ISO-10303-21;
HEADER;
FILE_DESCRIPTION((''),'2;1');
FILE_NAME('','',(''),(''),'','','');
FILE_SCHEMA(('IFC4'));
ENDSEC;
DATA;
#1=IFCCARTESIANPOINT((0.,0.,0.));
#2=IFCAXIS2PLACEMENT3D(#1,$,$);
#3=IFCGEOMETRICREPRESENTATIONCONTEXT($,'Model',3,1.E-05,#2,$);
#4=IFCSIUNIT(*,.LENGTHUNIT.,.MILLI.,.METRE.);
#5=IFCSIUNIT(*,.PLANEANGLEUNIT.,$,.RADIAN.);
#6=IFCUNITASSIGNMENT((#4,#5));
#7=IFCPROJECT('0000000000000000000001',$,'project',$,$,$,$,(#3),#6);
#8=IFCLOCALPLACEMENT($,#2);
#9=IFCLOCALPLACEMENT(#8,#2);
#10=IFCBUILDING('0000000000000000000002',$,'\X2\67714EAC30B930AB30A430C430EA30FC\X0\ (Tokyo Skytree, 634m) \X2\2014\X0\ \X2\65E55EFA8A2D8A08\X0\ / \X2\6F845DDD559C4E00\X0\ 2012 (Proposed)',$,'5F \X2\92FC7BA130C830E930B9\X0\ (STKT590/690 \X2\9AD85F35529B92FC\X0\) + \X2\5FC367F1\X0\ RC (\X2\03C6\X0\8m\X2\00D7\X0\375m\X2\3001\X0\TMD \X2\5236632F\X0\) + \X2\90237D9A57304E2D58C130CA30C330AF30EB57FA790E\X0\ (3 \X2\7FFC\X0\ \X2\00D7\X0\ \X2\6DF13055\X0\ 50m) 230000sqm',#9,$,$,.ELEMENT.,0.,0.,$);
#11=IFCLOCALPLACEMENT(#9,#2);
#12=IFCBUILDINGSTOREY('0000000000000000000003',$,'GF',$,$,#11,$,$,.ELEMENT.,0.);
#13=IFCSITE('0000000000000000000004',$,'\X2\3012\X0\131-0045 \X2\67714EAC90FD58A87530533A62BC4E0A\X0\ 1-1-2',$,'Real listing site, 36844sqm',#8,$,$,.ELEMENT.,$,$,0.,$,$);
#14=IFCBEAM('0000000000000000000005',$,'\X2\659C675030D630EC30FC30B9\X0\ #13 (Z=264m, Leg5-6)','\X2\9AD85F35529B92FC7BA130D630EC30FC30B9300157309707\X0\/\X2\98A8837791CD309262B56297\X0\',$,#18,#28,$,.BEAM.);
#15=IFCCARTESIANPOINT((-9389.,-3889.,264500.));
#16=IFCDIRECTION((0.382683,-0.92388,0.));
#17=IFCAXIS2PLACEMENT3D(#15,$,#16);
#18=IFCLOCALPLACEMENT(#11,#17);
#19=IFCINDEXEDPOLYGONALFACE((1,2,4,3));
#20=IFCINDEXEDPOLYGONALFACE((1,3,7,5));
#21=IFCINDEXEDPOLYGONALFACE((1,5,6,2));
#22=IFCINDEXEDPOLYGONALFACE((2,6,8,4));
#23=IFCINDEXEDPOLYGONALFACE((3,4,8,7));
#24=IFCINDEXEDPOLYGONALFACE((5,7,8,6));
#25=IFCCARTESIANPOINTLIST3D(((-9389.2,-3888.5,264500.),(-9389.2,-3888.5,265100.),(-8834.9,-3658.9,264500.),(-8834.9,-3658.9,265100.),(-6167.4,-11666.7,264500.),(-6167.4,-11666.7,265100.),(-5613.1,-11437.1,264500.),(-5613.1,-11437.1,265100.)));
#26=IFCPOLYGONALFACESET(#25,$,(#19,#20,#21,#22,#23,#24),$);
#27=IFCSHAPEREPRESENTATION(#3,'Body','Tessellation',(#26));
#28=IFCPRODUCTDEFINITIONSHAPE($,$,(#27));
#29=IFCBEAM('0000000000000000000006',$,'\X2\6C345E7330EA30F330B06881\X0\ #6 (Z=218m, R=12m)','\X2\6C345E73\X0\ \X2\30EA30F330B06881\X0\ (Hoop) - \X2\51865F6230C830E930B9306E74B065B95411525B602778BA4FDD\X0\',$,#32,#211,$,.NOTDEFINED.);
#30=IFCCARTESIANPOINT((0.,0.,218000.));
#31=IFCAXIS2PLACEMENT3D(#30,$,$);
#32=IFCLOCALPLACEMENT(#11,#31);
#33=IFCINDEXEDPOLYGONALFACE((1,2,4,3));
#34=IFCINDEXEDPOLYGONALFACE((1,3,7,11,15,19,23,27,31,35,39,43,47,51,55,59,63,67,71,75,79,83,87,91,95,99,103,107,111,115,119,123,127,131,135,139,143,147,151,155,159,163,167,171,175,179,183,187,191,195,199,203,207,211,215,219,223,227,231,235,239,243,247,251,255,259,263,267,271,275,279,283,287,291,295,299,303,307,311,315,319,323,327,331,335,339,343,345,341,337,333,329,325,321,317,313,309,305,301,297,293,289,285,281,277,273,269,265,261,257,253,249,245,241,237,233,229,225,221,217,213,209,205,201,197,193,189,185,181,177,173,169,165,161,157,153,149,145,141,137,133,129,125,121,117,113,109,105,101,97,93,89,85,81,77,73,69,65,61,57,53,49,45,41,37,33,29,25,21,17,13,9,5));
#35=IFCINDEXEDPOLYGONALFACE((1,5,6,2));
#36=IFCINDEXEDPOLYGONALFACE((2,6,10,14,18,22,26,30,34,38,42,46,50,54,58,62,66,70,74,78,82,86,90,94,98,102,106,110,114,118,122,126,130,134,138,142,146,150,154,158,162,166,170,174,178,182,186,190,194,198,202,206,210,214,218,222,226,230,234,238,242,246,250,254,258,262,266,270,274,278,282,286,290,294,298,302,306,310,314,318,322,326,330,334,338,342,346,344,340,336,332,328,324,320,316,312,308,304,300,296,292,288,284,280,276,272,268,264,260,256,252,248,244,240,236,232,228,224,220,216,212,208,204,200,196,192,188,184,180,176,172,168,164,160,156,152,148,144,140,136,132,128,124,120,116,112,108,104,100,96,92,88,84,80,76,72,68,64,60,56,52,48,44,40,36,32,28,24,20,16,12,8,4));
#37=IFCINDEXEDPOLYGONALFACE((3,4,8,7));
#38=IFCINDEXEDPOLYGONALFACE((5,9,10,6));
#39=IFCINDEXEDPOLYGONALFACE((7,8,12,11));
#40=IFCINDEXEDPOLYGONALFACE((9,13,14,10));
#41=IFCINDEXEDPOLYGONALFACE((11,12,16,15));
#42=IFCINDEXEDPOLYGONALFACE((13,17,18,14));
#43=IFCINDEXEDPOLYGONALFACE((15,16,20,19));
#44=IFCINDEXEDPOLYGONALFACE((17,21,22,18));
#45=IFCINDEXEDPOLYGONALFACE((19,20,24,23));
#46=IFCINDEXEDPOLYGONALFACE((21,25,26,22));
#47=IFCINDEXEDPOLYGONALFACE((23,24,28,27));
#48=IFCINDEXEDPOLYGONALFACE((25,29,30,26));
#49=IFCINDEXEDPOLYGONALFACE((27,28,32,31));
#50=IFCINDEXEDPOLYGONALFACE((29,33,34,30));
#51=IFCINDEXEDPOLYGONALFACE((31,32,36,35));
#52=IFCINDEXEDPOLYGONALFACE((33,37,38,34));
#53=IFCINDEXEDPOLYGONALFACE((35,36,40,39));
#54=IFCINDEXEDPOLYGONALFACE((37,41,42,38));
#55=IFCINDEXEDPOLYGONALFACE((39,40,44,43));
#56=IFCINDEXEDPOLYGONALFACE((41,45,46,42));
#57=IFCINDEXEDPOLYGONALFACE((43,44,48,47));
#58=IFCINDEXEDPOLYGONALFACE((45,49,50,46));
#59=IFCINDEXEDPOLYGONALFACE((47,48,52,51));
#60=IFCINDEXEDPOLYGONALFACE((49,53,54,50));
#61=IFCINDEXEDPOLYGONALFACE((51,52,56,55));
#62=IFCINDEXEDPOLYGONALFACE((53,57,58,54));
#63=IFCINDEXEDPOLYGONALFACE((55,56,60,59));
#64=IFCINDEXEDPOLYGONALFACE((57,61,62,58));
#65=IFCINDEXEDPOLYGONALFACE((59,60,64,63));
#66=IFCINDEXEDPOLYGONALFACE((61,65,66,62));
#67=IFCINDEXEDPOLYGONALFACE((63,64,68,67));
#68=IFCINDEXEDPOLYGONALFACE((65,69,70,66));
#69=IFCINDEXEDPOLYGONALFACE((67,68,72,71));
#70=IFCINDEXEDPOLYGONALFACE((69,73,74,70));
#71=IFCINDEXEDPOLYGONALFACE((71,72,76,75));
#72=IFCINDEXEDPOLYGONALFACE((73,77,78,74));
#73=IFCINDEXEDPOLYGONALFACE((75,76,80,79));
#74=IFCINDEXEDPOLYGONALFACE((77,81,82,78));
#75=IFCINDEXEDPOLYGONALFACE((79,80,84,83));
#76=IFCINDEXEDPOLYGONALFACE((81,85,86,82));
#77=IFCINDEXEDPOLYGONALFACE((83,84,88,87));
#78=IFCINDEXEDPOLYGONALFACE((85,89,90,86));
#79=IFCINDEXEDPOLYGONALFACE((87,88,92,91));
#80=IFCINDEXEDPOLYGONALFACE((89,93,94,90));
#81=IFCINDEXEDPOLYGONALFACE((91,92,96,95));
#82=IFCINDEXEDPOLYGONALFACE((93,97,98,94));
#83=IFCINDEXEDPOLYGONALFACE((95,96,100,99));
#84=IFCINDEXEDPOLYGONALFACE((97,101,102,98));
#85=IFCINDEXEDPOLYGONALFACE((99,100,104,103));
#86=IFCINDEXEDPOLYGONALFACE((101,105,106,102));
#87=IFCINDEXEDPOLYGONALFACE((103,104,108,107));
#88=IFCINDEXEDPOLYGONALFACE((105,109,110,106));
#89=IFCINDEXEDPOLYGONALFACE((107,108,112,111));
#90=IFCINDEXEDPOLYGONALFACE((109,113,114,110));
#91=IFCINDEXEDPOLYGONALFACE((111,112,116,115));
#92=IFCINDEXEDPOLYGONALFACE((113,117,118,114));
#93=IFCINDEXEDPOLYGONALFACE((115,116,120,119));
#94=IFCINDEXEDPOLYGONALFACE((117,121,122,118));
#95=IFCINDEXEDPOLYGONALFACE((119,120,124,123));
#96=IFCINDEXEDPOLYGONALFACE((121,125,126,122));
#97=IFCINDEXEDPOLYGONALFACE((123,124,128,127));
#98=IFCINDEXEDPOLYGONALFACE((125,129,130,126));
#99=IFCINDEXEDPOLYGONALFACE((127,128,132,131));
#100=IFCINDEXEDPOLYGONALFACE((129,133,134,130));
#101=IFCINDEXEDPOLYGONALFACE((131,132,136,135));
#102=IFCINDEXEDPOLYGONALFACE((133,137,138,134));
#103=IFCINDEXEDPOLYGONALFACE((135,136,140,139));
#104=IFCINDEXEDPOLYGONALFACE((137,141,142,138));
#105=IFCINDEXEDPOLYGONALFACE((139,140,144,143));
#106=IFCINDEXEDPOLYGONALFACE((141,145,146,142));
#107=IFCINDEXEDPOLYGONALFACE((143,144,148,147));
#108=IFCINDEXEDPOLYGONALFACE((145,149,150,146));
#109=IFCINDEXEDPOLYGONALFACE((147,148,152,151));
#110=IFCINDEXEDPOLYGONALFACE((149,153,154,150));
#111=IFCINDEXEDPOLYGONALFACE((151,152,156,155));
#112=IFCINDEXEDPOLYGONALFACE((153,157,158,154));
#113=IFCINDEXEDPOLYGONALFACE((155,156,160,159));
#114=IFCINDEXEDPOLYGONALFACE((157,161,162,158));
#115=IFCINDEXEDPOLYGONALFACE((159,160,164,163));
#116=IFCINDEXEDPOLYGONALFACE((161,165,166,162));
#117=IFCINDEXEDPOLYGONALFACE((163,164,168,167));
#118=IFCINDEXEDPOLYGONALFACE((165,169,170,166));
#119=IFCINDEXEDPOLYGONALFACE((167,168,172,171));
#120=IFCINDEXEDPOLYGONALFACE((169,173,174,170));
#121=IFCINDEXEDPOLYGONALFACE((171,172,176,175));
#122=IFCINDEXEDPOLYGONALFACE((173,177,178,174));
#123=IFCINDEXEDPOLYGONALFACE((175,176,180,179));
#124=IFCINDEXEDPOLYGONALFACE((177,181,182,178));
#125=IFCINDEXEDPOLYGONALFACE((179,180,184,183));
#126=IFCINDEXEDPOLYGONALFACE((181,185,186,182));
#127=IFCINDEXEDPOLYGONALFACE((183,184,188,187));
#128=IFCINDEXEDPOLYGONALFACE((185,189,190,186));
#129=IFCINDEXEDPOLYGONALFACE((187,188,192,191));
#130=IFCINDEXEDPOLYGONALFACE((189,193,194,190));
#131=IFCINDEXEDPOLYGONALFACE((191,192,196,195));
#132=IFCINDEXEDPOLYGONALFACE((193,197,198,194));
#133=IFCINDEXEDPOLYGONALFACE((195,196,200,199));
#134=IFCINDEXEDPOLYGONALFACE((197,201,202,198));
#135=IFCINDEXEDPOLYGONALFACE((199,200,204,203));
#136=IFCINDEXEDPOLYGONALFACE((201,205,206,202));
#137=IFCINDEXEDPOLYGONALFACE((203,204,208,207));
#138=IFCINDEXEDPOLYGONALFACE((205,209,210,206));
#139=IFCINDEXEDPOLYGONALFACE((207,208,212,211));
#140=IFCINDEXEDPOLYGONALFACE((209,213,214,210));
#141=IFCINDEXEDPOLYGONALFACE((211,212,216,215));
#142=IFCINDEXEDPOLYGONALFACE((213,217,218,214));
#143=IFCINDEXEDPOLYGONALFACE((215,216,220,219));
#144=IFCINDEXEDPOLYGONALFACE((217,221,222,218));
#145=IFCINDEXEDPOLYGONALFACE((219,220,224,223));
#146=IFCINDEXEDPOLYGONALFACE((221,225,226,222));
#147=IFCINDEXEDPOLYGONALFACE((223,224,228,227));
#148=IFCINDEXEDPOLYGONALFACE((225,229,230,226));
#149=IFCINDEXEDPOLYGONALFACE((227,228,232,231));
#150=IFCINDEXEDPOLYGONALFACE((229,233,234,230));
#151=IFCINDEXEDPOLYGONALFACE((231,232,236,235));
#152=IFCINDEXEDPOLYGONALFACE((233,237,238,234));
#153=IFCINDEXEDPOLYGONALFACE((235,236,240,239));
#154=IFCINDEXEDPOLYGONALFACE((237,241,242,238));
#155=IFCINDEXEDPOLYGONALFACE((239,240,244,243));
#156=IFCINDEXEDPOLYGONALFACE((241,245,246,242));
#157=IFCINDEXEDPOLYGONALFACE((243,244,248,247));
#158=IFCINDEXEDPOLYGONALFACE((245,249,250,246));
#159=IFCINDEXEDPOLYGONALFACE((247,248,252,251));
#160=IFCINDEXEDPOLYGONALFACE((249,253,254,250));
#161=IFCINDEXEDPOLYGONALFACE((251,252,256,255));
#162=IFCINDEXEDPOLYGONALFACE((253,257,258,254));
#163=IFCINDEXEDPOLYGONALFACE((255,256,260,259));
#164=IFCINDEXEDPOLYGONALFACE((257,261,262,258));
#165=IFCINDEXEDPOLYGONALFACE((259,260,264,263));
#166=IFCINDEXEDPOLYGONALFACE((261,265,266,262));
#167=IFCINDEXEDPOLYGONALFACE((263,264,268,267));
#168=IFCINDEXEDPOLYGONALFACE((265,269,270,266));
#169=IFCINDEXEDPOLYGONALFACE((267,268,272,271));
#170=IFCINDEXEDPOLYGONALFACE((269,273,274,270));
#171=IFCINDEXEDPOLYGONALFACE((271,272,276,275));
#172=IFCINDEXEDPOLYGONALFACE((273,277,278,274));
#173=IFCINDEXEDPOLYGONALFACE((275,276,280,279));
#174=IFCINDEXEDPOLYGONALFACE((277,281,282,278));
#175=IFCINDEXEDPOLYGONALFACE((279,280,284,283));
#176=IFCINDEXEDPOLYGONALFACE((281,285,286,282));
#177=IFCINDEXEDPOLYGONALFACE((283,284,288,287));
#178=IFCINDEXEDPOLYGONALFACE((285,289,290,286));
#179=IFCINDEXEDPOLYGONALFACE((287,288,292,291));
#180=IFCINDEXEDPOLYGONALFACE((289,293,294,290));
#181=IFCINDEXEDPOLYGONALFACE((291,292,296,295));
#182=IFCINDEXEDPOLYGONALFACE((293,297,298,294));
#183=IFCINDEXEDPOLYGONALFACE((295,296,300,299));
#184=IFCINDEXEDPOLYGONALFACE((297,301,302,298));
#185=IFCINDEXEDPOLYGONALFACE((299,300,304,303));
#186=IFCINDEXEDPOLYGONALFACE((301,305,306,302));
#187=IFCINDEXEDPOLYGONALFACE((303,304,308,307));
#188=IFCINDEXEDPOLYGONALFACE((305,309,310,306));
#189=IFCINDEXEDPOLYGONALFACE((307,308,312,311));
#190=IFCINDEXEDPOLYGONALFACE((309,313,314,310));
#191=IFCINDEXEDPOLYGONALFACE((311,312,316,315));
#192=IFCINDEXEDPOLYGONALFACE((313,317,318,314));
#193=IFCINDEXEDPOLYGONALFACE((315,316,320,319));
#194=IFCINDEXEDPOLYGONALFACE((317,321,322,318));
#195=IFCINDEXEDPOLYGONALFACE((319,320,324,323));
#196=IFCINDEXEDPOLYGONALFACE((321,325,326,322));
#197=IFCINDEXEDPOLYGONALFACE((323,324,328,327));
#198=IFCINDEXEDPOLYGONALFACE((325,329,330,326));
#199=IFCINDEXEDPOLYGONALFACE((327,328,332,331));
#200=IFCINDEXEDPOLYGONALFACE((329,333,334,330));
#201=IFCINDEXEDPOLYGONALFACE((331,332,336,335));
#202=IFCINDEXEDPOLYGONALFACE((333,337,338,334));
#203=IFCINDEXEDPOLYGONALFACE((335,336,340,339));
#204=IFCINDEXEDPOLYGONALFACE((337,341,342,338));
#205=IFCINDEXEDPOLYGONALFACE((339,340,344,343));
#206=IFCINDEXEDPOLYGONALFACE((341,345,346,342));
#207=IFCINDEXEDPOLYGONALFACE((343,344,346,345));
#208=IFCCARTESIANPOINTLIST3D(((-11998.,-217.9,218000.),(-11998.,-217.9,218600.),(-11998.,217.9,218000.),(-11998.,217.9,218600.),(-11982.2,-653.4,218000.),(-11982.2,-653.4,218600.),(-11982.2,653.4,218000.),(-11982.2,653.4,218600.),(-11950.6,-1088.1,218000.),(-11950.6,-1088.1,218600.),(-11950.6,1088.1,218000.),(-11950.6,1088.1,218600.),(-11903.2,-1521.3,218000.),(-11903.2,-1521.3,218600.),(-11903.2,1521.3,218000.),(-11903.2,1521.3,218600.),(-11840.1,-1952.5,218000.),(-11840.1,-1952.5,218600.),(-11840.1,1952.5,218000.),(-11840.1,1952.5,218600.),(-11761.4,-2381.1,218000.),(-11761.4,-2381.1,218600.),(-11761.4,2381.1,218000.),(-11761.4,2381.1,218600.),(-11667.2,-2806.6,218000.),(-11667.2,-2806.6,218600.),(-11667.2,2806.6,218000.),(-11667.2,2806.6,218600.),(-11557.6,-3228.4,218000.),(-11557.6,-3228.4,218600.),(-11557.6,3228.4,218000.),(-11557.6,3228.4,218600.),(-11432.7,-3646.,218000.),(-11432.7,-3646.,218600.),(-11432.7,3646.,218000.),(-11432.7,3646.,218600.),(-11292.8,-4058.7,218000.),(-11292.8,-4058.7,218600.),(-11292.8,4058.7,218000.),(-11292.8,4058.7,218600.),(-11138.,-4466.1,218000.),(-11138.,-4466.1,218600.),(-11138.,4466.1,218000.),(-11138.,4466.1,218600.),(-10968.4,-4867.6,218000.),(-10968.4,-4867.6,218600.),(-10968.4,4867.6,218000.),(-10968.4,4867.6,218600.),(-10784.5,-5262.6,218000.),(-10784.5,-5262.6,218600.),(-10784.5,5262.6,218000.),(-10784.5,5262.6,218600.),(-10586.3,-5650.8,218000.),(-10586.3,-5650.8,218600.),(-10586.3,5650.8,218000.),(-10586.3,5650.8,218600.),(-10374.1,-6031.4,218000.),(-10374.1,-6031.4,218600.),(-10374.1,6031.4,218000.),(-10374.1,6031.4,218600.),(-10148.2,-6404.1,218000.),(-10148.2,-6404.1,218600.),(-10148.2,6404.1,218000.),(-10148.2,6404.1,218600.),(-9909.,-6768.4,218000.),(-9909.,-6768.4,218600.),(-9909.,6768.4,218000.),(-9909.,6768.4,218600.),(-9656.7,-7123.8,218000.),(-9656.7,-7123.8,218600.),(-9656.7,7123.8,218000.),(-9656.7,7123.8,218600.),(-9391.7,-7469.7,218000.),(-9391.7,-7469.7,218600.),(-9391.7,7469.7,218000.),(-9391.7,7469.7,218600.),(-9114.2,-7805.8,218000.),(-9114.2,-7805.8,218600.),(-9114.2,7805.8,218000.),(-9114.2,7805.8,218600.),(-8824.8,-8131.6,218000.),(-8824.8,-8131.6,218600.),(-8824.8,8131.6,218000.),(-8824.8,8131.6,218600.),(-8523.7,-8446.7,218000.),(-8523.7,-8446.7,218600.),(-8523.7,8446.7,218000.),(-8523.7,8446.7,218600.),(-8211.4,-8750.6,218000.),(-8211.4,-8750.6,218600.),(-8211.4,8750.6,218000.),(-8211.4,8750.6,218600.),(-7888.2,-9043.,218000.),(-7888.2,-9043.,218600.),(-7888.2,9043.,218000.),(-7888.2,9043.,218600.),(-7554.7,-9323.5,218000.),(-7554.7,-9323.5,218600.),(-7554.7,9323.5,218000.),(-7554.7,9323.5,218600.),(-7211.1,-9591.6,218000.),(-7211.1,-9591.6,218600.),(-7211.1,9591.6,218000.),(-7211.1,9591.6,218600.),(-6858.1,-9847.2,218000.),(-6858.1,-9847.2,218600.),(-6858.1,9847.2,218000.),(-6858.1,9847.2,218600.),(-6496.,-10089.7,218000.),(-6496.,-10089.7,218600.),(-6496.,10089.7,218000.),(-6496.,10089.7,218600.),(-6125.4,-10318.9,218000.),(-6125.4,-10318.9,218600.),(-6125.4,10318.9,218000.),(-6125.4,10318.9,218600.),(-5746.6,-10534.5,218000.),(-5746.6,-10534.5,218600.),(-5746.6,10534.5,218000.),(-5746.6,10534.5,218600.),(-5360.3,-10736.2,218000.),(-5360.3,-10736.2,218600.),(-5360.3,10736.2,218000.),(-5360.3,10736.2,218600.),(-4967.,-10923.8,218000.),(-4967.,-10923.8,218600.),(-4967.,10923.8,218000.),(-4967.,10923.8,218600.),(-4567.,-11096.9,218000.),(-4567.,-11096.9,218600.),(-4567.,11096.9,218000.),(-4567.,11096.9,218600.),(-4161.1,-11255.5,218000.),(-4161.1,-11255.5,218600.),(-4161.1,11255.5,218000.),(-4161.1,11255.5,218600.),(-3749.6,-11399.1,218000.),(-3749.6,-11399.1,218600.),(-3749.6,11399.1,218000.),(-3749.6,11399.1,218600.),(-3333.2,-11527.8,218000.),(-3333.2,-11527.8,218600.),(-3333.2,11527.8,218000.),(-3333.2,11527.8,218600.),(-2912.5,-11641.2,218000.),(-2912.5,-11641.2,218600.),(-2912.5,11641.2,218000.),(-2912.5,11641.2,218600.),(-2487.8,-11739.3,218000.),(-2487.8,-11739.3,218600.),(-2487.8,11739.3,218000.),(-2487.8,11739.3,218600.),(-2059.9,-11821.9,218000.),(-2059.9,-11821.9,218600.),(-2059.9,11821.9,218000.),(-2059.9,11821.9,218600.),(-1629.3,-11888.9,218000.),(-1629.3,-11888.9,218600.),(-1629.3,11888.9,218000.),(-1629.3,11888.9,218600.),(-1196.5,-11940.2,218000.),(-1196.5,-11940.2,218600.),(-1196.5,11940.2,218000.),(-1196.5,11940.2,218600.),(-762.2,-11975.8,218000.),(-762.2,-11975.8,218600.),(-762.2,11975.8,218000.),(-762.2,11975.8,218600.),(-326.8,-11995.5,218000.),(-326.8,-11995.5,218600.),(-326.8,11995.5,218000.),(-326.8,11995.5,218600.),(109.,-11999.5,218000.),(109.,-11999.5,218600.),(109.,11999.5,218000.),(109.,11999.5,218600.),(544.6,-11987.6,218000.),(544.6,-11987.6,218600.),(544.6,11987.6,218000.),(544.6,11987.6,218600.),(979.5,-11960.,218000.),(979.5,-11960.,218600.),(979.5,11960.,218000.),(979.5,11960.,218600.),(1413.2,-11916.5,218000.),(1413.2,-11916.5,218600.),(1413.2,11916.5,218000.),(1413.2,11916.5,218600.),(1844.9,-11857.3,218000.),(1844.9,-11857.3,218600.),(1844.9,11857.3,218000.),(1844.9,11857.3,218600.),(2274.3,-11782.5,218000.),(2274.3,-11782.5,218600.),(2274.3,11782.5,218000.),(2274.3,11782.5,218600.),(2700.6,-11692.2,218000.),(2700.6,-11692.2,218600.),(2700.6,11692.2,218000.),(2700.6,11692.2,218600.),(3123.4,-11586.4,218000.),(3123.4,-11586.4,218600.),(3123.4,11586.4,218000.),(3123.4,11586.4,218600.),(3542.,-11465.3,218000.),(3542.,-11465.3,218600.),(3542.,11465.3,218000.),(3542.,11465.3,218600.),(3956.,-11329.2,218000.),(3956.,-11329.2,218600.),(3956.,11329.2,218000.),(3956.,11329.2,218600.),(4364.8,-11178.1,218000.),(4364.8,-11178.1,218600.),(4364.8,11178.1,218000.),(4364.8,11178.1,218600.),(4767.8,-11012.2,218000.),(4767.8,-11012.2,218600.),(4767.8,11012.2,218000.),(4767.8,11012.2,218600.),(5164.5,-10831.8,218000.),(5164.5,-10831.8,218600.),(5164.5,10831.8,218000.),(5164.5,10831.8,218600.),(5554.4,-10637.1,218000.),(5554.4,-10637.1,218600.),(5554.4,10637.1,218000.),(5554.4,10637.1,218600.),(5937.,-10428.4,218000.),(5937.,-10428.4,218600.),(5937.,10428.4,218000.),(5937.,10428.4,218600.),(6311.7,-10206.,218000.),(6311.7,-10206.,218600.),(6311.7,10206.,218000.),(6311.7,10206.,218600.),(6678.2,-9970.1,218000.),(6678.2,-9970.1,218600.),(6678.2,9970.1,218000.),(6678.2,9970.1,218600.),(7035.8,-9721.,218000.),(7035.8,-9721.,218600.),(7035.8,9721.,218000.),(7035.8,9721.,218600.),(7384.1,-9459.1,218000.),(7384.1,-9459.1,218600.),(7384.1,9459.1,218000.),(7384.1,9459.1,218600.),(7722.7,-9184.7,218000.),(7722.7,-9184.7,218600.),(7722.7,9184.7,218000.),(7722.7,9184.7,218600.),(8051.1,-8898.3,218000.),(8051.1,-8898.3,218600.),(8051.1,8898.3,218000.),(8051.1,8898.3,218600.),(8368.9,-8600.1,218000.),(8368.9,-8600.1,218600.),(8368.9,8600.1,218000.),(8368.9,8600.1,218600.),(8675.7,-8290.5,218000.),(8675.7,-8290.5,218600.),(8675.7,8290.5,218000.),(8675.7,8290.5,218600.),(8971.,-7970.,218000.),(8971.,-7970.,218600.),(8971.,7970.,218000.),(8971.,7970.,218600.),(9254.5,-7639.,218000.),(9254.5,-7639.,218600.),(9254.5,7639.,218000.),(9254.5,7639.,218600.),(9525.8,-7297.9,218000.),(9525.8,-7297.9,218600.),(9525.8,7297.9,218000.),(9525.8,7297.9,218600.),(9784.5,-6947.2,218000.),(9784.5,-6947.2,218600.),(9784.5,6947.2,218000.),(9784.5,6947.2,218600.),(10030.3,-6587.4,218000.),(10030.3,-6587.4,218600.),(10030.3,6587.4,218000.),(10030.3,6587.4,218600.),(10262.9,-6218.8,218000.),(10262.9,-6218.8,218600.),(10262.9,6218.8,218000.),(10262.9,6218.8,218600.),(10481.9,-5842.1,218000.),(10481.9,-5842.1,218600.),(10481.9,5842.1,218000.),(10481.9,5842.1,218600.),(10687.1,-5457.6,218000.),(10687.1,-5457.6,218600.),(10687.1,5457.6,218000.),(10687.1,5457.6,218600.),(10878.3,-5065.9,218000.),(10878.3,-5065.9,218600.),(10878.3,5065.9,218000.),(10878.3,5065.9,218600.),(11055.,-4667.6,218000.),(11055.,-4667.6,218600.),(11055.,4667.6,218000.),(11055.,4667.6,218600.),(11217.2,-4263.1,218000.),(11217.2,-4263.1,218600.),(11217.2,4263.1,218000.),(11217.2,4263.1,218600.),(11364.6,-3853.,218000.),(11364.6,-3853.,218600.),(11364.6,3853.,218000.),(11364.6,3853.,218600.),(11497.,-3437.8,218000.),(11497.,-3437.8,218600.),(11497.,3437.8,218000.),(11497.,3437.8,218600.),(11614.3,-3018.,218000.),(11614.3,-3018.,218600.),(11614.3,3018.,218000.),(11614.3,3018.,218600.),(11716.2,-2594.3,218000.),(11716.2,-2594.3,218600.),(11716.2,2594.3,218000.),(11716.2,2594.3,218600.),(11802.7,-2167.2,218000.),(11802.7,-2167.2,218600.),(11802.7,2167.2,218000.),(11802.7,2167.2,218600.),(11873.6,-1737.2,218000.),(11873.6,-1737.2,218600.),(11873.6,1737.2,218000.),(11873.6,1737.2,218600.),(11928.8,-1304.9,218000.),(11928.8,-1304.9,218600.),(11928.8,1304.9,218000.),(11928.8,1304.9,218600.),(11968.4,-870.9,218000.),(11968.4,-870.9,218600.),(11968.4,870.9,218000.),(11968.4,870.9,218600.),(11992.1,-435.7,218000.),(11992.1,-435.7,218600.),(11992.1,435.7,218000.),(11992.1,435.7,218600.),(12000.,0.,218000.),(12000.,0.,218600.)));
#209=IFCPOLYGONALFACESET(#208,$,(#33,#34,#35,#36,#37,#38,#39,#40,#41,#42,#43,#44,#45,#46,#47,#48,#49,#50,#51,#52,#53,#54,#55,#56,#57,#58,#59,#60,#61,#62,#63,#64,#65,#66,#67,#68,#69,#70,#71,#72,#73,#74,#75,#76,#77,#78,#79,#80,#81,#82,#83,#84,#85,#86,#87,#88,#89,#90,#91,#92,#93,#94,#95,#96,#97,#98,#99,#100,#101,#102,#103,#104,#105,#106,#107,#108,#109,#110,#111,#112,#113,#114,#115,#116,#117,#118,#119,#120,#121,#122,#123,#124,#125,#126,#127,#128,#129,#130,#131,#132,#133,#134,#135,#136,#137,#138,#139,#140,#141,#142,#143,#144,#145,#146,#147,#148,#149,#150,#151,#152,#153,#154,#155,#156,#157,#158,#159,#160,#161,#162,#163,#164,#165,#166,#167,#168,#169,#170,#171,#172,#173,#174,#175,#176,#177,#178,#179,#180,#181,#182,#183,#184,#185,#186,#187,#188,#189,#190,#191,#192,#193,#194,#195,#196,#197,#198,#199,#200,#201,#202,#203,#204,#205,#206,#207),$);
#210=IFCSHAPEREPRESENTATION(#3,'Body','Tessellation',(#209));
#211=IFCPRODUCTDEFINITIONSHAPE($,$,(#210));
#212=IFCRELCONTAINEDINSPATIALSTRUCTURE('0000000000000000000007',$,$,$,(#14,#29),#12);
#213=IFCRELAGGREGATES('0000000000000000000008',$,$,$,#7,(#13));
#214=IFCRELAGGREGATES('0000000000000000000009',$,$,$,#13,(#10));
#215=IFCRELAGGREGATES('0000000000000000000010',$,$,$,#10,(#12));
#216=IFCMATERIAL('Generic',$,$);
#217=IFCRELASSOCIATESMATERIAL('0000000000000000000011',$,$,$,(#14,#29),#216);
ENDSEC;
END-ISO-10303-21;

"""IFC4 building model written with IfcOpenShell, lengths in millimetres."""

from ifc_helpers import new_model, si_unit, frame, frame_2d, origin, origin_2d, place, context, project, spatial, rectangle, circle, extrude, material, element, save


model = new_model("IFC4")

# Units and contexts
model_context = context("Model", 3, precision=1e-05, world=origin())
ifc_project = project(units=[si_unit("LENGTHUNIT", "METRE", prefix="MILLI"), si_unit("PLANEANGLEUNIT", "RADIAN")], contexts=[model_context])

# Site, building, storey
site_placement = place(None, origin())
site = spatial("IfcSite", under=ifc_project, at=site_placement, Name="〒131-0045 東京都墨田区押上 1-1-2", ObjectType="Real listing site, 36844sqm", CompositionType="ELEMENT", RefElevation=0.0)
building_placement = place(site_placement, origin())
building = spatial("IfcBuilding", under=site, at=building_placement, Name="東京スカイツリー (Tokyo Skytree, 634m) — 日建設計 / 澄川喜一 2012 (Proposed)", ObjectType="5F 鋼管トラス (STKT590/690 高張力鋼) + 心柱 RC (φ8m×375m、TMD 制振) + 連続地中壁ナックル基礎 (3 翼 × 深さ 50m) 230000sqm", CompositionType="ELEMENT", ElevationOfRefHeight=0.0, ElevationOfTerrain=0.0)
storey_placement = place(building_placement, origin())
storey = spatial("IfcBuildingStorey", under=building, at=storey_placement, Name="GF", CompositionType="ELEMENT", Elevation=0.0)

# Shared definitions
ifc_material_1 = material(Name="Generic")

# Beams
beam_1_placement = place(storey_placement, frame((-9389.0, -3889.0, 264500.0), x_axis=(0.382683, -0.92388, 0.0)))
element("IfcBeam", 1, at=beam_1_placement, inside=storey, material=ifc_material_1, Name="斜材ブレース #13 (Z=264m, Leg5-6)", Description="高張力鋼管ブレース、地震/風荷重を抵抗", PredefinedType="BEAM", context=model_context, shape_type="SweptSolid", body=[
    extrude(rectangle(XDim=8419.0, YDim=600.0, at=frame_2d((4209.0, 300.0))), frame((-9389.0, -3889.0, 264500.0), x_axis=(0.382683, -0.92388, 0.0)), (0.0, 0.0, 1.0), 600.0),
])
beam_2_placement = place(storey_placement, frame((0.0, 0.0, 218000.0)))
element("IfcBeam", 2, at=beam_2_placement, inside=storey, material=ifc_material_1, Name="水平リング梁 #6 (Z=218m, R=12m)", Description="水平 リング梁 (Hoop) - 円形トラスの環方向剛性確保", PredefinedType="NOTDEFINED", context=model_context, shape_type="SweptSolid", body=[
    extrude(circle(Radius=12000.0, at=origin_2d()), frame((0.0, 0.0, 218000.0)), (0.0, 0.0, 1.0), 600.0),
])

save(model, "model.ifc")
